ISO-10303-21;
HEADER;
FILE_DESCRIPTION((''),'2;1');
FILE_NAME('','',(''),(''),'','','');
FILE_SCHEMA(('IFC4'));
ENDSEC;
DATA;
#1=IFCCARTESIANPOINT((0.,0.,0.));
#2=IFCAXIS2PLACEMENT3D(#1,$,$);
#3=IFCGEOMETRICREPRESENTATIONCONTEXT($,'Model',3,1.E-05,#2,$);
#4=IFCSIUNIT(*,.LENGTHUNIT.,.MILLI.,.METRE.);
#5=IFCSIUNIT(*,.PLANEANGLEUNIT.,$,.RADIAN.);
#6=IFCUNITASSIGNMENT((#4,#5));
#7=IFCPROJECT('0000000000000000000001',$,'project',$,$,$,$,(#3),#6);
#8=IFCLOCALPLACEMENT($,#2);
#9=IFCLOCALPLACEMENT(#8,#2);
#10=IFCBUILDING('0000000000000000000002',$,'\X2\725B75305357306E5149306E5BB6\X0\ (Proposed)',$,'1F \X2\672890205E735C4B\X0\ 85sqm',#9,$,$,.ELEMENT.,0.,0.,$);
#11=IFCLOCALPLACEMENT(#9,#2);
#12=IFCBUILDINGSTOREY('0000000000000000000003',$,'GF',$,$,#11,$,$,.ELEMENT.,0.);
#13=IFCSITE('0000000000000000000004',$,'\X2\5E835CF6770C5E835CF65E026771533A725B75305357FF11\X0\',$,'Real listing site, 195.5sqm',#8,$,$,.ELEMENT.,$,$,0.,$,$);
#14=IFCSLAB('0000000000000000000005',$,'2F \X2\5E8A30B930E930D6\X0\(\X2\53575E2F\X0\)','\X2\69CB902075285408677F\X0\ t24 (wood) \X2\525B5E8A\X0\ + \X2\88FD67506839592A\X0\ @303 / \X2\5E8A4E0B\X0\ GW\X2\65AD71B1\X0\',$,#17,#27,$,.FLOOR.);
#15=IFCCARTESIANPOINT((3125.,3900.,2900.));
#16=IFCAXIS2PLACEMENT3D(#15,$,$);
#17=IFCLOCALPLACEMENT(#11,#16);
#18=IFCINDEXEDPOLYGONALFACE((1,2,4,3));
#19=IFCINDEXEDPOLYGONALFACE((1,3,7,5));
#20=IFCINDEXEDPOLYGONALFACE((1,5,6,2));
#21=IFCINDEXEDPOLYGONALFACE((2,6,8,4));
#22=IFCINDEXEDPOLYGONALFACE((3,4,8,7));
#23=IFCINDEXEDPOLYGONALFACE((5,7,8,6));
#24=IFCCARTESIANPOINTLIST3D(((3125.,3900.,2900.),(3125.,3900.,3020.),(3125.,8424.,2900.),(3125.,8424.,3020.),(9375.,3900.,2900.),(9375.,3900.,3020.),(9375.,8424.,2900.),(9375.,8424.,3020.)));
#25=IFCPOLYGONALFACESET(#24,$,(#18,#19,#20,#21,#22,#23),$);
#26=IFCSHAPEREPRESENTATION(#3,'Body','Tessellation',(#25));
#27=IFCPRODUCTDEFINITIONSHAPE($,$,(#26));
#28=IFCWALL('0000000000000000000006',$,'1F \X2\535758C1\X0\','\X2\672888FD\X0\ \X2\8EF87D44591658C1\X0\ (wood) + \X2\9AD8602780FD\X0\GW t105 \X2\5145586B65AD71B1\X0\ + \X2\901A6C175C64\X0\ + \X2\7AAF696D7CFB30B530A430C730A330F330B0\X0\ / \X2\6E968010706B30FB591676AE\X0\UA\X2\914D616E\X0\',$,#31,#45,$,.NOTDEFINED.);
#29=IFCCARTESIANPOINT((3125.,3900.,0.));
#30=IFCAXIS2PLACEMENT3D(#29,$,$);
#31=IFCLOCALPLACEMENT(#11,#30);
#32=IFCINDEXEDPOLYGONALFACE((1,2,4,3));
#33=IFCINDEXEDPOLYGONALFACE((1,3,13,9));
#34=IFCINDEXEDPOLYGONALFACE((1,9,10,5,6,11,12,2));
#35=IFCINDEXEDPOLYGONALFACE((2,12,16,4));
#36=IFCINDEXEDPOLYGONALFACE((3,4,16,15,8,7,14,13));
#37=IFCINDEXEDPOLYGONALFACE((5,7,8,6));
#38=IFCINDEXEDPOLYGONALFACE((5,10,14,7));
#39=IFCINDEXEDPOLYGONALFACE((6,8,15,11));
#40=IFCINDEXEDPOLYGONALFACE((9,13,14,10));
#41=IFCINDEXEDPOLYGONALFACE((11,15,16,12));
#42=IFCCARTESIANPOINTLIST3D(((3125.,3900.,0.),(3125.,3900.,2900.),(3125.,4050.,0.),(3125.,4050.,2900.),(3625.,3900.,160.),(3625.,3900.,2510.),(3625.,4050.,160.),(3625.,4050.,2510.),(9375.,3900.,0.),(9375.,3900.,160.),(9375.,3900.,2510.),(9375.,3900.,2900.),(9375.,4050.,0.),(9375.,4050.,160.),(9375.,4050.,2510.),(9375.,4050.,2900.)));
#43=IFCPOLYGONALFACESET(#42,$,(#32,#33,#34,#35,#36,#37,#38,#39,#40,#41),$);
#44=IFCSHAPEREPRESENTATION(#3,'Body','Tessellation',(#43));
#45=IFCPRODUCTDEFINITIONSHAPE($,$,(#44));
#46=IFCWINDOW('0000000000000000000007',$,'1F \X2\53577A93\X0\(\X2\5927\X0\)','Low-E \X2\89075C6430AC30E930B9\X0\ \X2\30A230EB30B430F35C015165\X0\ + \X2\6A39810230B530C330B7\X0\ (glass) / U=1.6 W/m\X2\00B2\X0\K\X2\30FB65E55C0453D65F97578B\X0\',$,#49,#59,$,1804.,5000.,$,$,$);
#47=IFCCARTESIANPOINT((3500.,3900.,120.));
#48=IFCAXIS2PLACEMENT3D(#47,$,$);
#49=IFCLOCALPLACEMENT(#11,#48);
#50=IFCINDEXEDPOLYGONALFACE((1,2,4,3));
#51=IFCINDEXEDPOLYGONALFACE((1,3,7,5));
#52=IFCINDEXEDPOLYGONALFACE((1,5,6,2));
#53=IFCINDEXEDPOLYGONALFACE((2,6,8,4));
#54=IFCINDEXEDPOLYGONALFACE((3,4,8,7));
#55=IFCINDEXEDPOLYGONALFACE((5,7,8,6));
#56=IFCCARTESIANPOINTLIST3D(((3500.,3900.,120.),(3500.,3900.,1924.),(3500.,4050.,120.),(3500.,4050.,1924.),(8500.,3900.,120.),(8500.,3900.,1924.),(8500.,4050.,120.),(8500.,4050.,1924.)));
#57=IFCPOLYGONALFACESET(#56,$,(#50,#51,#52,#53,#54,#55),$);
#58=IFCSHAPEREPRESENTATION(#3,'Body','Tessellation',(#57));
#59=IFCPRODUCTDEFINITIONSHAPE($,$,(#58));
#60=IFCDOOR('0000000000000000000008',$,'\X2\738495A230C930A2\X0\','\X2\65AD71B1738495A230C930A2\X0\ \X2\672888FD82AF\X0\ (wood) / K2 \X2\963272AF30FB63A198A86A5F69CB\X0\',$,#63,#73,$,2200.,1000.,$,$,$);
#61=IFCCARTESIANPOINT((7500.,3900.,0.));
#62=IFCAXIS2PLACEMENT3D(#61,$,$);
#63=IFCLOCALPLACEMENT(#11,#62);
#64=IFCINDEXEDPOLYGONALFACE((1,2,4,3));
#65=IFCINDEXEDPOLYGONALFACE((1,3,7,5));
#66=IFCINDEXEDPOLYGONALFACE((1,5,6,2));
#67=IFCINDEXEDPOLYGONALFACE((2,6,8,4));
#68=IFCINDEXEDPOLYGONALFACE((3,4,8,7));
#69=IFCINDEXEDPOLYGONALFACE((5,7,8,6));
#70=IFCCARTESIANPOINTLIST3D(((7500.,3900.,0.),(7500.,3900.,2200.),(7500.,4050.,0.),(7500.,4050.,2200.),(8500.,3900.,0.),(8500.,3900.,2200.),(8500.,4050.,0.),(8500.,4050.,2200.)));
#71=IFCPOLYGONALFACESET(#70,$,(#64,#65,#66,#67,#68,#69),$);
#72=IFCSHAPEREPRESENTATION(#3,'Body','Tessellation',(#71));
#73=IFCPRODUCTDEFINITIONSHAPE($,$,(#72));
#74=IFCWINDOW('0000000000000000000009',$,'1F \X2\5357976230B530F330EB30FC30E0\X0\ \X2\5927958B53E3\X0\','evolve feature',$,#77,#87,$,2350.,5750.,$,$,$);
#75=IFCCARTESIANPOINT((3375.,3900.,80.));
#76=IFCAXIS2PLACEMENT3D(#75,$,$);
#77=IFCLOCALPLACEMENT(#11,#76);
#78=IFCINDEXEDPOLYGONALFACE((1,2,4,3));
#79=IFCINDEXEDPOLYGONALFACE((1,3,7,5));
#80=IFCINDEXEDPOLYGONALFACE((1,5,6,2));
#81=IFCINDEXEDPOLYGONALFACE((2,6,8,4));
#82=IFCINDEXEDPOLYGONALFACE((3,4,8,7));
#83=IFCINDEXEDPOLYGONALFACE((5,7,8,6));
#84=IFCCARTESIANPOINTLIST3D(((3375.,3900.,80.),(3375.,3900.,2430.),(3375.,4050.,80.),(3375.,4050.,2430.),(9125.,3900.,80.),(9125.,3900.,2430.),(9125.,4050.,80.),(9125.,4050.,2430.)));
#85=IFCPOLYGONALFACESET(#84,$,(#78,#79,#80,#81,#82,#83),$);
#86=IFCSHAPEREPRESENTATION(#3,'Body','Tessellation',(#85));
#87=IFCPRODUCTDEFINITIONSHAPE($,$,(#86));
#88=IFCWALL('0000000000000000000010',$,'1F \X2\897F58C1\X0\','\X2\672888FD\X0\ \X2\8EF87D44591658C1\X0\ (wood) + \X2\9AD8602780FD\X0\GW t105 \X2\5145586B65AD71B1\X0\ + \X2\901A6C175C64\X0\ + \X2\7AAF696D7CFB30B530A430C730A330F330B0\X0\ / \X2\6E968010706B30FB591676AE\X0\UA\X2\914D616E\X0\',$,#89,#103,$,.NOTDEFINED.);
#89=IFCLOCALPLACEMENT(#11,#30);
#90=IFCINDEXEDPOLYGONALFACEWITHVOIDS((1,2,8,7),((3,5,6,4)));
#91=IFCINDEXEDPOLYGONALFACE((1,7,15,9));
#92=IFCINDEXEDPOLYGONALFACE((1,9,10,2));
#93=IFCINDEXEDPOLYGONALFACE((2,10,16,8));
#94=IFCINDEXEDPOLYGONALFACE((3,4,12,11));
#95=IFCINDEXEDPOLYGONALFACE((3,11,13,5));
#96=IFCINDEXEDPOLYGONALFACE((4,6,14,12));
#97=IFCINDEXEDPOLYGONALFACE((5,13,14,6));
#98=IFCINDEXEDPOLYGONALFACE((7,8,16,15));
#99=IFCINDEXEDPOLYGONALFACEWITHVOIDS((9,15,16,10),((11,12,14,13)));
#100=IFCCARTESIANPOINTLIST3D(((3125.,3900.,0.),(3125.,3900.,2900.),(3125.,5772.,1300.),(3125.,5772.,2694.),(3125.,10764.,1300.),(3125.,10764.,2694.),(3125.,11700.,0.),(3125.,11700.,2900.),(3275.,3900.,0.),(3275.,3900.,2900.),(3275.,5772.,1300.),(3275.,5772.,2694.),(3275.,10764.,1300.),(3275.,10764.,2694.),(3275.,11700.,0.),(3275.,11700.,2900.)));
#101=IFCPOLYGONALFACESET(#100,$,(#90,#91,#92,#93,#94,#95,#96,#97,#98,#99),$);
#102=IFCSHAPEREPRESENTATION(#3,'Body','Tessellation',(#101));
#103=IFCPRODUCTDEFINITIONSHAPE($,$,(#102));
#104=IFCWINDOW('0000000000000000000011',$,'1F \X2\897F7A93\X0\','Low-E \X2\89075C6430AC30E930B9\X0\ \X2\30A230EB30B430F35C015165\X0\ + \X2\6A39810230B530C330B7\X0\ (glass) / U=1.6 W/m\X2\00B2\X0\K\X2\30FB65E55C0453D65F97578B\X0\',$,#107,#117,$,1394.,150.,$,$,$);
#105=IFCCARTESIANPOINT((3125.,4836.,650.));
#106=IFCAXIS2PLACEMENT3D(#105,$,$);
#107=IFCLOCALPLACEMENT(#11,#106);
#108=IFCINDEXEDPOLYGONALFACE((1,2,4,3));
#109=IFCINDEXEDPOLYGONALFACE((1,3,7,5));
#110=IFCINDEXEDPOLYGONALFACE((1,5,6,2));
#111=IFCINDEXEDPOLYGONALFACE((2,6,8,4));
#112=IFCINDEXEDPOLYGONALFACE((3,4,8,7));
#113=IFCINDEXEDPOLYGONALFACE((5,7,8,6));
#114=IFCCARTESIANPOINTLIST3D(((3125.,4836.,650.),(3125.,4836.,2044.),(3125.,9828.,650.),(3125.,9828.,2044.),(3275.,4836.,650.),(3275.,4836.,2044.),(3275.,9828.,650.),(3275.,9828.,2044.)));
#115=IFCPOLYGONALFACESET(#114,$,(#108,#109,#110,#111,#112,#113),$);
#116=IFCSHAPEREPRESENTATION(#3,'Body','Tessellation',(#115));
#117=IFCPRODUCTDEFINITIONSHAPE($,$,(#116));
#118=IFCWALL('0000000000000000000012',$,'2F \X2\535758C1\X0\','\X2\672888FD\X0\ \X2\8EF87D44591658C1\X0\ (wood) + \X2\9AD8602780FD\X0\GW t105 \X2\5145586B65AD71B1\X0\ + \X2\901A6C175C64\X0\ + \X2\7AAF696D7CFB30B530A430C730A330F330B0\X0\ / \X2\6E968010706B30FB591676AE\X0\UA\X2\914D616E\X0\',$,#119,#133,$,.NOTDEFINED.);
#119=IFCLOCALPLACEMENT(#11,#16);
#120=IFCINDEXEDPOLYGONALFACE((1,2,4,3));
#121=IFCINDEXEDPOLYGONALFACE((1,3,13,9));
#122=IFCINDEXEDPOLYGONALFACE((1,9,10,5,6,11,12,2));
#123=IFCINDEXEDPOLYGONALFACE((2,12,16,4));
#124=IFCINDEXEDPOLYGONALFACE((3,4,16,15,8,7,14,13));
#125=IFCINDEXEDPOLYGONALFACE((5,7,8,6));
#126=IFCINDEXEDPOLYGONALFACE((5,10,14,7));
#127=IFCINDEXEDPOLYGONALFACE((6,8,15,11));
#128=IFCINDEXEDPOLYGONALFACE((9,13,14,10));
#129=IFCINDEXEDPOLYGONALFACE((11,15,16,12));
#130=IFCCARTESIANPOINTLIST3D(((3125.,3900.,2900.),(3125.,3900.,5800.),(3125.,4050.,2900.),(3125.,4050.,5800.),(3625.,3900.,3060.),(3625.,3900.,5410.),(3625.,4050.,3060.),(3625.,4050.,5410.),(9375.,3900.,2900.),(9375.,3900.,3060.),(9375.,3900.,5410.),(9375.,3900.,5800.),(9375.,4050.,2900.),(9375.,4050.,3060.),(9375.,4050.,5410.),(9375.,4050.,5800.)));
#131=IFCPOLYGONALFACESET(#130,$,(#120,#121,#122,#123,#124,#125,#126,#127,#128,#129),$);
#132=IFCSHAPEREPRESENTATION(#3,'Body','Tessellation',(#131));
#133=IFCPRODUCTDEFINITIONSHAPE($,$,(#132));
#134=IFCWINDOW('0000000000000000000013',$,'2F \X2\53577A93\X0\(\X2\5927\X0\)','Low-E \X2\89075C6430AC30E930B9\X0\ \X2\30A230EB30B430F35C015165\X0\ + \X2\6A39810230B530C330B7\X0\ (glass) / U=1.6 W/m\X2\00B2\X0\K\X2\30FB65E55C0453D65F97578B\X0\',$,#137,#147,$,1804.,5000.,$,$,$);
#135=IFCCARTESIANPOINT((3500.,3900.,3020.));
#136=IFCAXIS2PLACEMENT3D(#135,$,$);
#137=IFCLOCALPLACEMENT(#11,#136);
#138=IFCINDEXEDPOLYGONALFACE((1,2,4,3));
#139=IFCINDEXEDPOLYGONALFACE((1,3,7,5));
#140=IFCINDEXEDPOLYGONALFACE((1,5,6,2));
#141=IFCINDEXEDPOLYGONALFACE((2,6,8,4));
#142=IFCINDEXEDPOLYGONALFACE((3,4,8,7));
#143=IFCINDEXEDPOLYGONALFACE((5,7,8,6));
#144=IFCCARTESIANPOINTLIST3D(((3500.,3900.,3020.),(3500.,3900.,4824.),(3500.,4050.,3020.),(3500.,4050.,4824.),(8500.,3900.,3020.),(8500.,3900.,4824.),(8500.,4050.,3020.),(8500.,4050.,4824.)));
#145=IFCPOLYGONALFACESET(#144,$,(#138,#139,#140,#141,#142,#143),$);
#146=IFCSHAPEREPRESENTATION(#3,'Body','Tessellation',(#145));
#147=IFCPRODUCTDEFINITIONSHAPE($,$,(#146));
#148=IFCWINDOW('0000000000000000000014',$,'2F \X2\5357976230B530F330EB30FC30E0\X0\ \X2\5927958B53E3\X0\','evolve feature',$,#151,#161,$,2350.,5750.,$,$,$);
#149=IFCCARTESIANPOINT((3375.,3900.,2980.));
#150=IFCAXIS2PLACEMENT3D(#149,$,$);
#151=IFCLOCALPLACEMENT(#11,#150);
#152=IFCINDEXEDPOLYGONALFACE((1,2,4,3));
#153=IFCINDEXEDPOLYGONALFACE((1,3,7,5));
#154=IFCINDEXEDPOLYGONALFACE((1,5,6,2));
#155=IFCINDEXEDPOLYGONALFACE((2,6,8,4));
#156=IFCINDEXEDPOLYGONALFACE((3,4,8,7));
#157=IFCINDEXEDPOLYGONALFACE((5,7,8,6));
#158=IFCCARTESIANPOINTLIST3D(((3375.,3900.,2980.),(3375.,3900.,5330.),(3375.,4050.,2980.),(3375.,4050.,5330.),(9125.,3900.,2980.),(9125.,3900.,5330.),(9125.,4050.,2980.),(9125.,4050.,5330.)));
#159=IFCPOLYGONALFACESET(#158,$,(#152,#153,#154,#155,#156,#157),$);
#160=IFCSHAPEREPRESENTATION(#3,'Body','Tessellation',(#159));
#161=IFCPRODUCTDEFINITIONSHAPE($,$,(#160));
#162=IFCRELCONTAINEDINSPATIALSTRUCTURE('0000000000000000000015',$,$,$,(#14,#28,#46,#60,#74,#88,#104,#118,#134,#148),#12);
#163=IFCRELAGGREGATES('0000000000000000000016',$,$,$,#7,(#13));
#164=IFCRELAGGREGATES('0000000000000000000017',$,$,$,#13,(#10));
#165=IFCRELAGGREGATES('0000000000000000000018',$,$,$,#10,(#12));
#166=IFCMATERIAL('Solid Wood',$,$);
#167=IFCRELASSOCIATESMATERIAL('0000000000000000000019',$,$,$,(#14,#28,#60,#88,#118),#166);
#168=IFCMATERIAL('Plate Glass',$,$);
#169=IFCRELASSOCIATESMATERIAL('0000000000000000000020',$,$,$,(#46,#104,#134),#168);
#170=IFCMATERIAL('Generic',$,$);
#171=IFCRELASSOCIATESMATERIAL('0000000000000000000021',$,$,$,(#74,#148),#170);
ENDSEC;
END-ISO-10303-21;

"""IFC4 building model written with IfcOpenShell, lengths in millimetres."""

from ifc_helpers import new_model, si_unit, frame, frame_2d, origin, place, context, project, spatial, rectangle, extrude, material, element, fill, save


model = new_model("IFC4")

# Units and contexts
model_context = context("Model", 3, precision=1e-05, world=origin())
ifc_project = project(units=[si_unit("LENGTHUNIT", "METRE", prefix="MILLI"), si_unit("PLANEANGLEUNIT", "RADIAN")], contexts=[model_context])

# Site, building, storey
site_placement = place(None, origin())
site = spatial("IfcSite", under=ifc_project, at=site_placement, Name="広島県広島市東区牛田南１", ObjectType="Real listing site, 195.5sqm", CompositionType="ELEMENT", RefElevation=0.0)
building_placement = place(site_placement, origin())
building = spatial("IfcBuilding", under=site, at=building_placement, Name="牛田南の光の家 (Proposed)", ObjectType="1F 木造平屋 85sqm", CompositionType="ELEMENT", ElevationOfRefHeight=0.0, ElevationOfTerrain=0.0)
storey_placement = place(building_placement, origin())
storey = spatial("IfcBuildingStorey", under=building, at=storey_placement, Name="GF", CompositionType="ELEMENT", Elevation=0.0)

# Slab
ifc_material_1 = material(Name="Solid Wood")
slab_1_placement = place(storey_placement, frame((3125.0, 3900.0, 2900.0)))
element("IfcSlab", 1, at=slab_1_placement, inside=storey, material=ifc_material_1, Name="2F 床スラブ(南帯)", Description="構造用合板 t24 (wood) 剛床 + 製材根太 @303 / 床下 GW断熱", PredefinedType="FLOOR", context=model_context, shape_type="SweptSolid", body=[
    extrude(rectangle(XDim=6250.0, YDim=4524.0, at=frame_2d((3125.0, 2262.0))), frame((3125.0, 3900.0, 2900.0)), (0.0, 0.0, 1.0), 120.0),
])
ifc_material_2 = material(Name="Generic")

# Wall, openings, windows, door
wall_1_placement = place(storey_placement, frame((3125.0, 3900.0, 0.0)))
wall_1 = element("IfcWall", 2, at=wall_1_placement, inside=storey, material=ifc_material_1, Name="1F 南壁", Description="木製 軸組外壁 (wood) + 高性能GW t105 充填断熱 + 通気層 + 窯業系サイディング / 準耐火・外皮UA配慮", PredefinedType="NOTDEFINED", context=model_context, shape_type="SweptSolid", body=[
    extrude(rectangle(XDim=6250.0, YDim=150.0, at=frame_2d((3125.0, 75.0))), frame((3125.0, 3900.0, 0.0)), (0.0, 0.0, 1.0), 2900.0),
])
opening_1_placement = place(storey_placement, frame((3500.0, 3900.0, 120.0)))
opening_1 = element("IfcOpeningElement", 3, at=opening_1_placement, cuts=wall_1, PredefinedType="NOTDEFINED", context=model_context, shape_type="SweptSolid", body=[
    extrude(rectangle(XDim=5000.0, YDim=150.0, at=frame_2d((2500.0, 75.0))), frame((3500.0, 3900.0, 120.0)), (0.0, 0.0, 1.0), 1804.0),
])
opening_2_placement = place(storey_placement, frame((7500.0, 3900.0, 0.0)))
opening_2 = element("IfcOpeningElement", 4, at=opening_2_placement, cuts=wall_1, PredefinedType="NOTDEFINED", context=model_context, shape_type="SweptSolid", body=[
    extrude(rectangle(XDim=1000.0, YDim=150.0, at=frame_2d((500.0, 75.0))), frame((7500.0, 3900.0, 0.0)), (0.0, 0.0, 1.0), 2200.0),
])
opening_3_placement = place(storey_placement, frame((3375.0, 3900.0, 80.0)))
opening_3 = element("IfcOpeningElement", 5, at=opening_3_placement, cuts=wall_1, PredefinedType="NOTDEFINED", context=model_context, shape_type="SweptSolid", body=[
    extrude(rectangle(XDim=5750.0, YDim=150.0, at=frame_2d((2875.0, 75.0))), frame((3375.0, 3900.0, 80.0)), (0.0, 0.0, 1.0), 2350.0),
])
ifc_material_3 = material(Name="Plate Glass")
window_1_placement = place(storey_placement, frame((3500.0, 3900.0, 120.0)))
window_1 = element("IfcWindow", 6, at=window_1_placement, inside=storey, material=ifc_material_3, Name="1F 南窓(大)", Description="Low-E 複層ガラス アルゴン封入 + 樹脂サッシ (glass) / U=1.6 W/m²K・日射取得型", OverallHeight=1804.0, OverallWidth=5000.0, context=model_context, shape_type="SweptSolid", body=[
    extrude(rectangle(XDim=5000.0, YDim=150.0, at=frame_2d((2500.0, 75.0))), frame((3500.0, 3900.0, 120.0)), (0.0, 0.0, 1.0), 1804.0),
])
fill(opening_1, window_1)
door_placement = place(storey_placement, frame((7500.0, 3900.0, 0.0)))
door = element("IfcDoor", 7, at=door_placement, inside=storey, material=ifc_material_1, Name="玄関ドア", Description="断熱玄関ドア 木製芯 (wood) / K2 防犯・採風機構", OverallHeight=2200.0, OverallWidth=1000.0, context=model_context, shape_type="SweptSolid", body=[
    extrude(rectangle(XDim=1000.0, YDim=150.0, at=frame_2d((500.0, 75.0))), frame((7500.0, 3900.0, 0.0)), (0.0, 0.0, 1.0), 2200.0),
])
fill(opening_2, door)
window_2_placement = place(storey_placement, frame((3375.0, 3900.0, 80.0)))
window_2 = element("IfcWindow", 8, at=window_2_placement, inside=storey, material=ifc_material_2, Name="1F 南面サンルーム 大開口", Description="evolve feature", OverallHeight=2350.0, OverallWidth=5750.0, context=model_context, shape_type="SweptSolid", body=[
    extrude(rectangle(XDim=5750.0, YDim=150.0, at=frame_2d((2875.0, 75.0))), frame((3375.0, 3900.0, 80.0)), (0.0, 0.0, 1.0), 2350.0),
])
fill(opening_3, window_2)

# Wall, opening, window
wall_2_placement = place(storey_placement, frame((3125.0, 3900.0, 0.0)))
wall_2 = element("IfcWall", 9, at=wall_2_placement, inside=storey, material=ifc_material_1, Name="1F 西壁", Description="木製 軸組外壁 (wood) + 高性能GW t105 充填断熱 + 通気層 + 窯業系サイディング / 準耐火・外皮UA配慮", PredefinedType="NOTDEFINED", context=model_context, shape_type="SweptSolid", body=[
    extrude(rectangle(XDim=150.0, YDim=7800.0, at=frame_2d((75.0, 3900.0))), frame((3125.0, 3900.0, 0.0)), (0.0, 0.0, 1.0), 2900.0),
])
opening_4_placement = place(storey_placement, frame((3125.0, 4836.0, 650.0)))
opening_4 = element("IfcOpeningElement", 10, at=opening_4_placement, cuts=wall_2, PredefinedType="NOTDEFINED", context=model_context, shape_type="SweptSolid", body=[
    extrude(rectangle(XDim=150.0, YDim=4992.0, at=frame_2d((75.0, 2496.0))), frame((3125.0, 4836.0, 650.0)), (0.0, 0.0, 1.0), 1394.0),
])
window_3_placement = place(storey_placement, frame((3125.0, 4836.0, 650.0)))
window_3 = element("IfcWindow", 11, at=window_3_placement, inside=storey, material=ifc_material_3, Name="1F 西窓", Description="Low-E 複層ガラス アルゴン封入 + 樹脂サッシ (glass) / U=1.6 W/m²K・日射取得型", OverallHeight=1394.0, OverallWidth=150.0, context=model_context, shape_type="SweptSolid", body=[
    extrude(rectangle(XDim=150.0, YDim=4992.0, at=frame_2d((75.0, 2496.0))), frame((3125.0, 4836.0, 650.0)), (0.0, 0.0, 1.0), 1394.0),
])
fill(opening_4, window_3)

# Wall, openings, windows
wall_3_placement = place(storey_placement, frame((3125.0, 3900.0, 2900.0)))
wall_3 = element("IfcWall", 12, at=wall_3_placement, inside=storey, material=ifc_material_1, Name="2F 南壁", Description="木製 軸組外壁 (wood) + 高性能GW t105 充填断熱 + 通気層 + 窯業系サイディング / 準耐火・外皮UA配慮", PredefinedType="NOTDEFINED", context=model_context, shape_type="SweptSolid", body=[
    extrude(rectangle(XDim=6250.0, YDim=150.0, at=frame_2d((3125.0, 75.0))), frame((3125.0, 3900.0, 2900.0)), (0.0, 0.0, 1.0), 2900.0),
])
opening_5_placement = place(storey_placement, frame((3500.0, 3900.0, 3020.0)))
opening_5 = element("IfcOpeningElement", 13, at=opening_5_placement, cuts=wall_3, PredefinedType="NOTDEFINED", context=model_context, shape_type="SweptSolid", body=[
    extrude(rectangle(XDim=5000.0, YDim=150.0, at=frame_2d((2500.0, 75.0))), frame((3500.0, 3900.0, 3020.0)), (0.0, 0.0, 1.0), 1804.0),
])
opening_6_placement = place(storey_placement, frame((3375.0, 3900.0, 2980.0)))
opening_6 = element("IfcOpeningElement", 14, at=opening_6_placement, cuts=wall_3, PredefinedType="NOTDEFINED", context=model_context, shape_type="SweptSolid", body=[
    extrude(rectangle(XDim=5750.0, YDim=150.0, at=frame_2d((2875.0, 75.0))), frame((3375.0, 3900.0, 2980.0)), (0.0, 0.0, 1.0), 2350.0),
])
window_4_placement = place(storey_placement, frame((3500.0, 3900.0, 3020.0)))
window_4 = element("IfcWindow", 15, at=window_4_placement, inside=storey, material=ifc_material_3, Name="2F 南窓(大)", Description="Low-E 複層ガラス アルゴン封入 + 樹脂サッシ (glass) / U=1.6 W/m²K・日射取得型", OverallHeight=1804.0, OverallWidth=5000.0, context=model_context, shape_type="SweptSolid", body=[
    extrude(rectangle(XDim=5000.0, YDim=150.0, at=frame_2d((2500.0, 75.0))), frame((3500.0, 3900.0, 3020.0)), (0.0, 0.0, 1.0), 1804.0),
])
fill(opening_5, window_4)
window_5_placement = place(storey_placement, frame((3375.0, 3900.0, 2980.0)))
window_5 = element("IfcWindow", 16, at=window_5_placement, inside=storey, material=ifc_material_2, Name="2F 南面サンルーム 大開口", Description="evolve feature", OverallHeight=2350.0, OverallWidth=5750.0, context=model_context, shape_type="SweptSolid", body=[
    extrude(rectangle(XDim=5750.0, YDim=150.0, at=frame_2d((2875.0, 75.0))), frame((3375.0, 3900.0, 2980.0)), (0.0, 0.0, 1.0), 2350.0),
])
fill(opening_6, window_5)

save(model, "model.ifc")
